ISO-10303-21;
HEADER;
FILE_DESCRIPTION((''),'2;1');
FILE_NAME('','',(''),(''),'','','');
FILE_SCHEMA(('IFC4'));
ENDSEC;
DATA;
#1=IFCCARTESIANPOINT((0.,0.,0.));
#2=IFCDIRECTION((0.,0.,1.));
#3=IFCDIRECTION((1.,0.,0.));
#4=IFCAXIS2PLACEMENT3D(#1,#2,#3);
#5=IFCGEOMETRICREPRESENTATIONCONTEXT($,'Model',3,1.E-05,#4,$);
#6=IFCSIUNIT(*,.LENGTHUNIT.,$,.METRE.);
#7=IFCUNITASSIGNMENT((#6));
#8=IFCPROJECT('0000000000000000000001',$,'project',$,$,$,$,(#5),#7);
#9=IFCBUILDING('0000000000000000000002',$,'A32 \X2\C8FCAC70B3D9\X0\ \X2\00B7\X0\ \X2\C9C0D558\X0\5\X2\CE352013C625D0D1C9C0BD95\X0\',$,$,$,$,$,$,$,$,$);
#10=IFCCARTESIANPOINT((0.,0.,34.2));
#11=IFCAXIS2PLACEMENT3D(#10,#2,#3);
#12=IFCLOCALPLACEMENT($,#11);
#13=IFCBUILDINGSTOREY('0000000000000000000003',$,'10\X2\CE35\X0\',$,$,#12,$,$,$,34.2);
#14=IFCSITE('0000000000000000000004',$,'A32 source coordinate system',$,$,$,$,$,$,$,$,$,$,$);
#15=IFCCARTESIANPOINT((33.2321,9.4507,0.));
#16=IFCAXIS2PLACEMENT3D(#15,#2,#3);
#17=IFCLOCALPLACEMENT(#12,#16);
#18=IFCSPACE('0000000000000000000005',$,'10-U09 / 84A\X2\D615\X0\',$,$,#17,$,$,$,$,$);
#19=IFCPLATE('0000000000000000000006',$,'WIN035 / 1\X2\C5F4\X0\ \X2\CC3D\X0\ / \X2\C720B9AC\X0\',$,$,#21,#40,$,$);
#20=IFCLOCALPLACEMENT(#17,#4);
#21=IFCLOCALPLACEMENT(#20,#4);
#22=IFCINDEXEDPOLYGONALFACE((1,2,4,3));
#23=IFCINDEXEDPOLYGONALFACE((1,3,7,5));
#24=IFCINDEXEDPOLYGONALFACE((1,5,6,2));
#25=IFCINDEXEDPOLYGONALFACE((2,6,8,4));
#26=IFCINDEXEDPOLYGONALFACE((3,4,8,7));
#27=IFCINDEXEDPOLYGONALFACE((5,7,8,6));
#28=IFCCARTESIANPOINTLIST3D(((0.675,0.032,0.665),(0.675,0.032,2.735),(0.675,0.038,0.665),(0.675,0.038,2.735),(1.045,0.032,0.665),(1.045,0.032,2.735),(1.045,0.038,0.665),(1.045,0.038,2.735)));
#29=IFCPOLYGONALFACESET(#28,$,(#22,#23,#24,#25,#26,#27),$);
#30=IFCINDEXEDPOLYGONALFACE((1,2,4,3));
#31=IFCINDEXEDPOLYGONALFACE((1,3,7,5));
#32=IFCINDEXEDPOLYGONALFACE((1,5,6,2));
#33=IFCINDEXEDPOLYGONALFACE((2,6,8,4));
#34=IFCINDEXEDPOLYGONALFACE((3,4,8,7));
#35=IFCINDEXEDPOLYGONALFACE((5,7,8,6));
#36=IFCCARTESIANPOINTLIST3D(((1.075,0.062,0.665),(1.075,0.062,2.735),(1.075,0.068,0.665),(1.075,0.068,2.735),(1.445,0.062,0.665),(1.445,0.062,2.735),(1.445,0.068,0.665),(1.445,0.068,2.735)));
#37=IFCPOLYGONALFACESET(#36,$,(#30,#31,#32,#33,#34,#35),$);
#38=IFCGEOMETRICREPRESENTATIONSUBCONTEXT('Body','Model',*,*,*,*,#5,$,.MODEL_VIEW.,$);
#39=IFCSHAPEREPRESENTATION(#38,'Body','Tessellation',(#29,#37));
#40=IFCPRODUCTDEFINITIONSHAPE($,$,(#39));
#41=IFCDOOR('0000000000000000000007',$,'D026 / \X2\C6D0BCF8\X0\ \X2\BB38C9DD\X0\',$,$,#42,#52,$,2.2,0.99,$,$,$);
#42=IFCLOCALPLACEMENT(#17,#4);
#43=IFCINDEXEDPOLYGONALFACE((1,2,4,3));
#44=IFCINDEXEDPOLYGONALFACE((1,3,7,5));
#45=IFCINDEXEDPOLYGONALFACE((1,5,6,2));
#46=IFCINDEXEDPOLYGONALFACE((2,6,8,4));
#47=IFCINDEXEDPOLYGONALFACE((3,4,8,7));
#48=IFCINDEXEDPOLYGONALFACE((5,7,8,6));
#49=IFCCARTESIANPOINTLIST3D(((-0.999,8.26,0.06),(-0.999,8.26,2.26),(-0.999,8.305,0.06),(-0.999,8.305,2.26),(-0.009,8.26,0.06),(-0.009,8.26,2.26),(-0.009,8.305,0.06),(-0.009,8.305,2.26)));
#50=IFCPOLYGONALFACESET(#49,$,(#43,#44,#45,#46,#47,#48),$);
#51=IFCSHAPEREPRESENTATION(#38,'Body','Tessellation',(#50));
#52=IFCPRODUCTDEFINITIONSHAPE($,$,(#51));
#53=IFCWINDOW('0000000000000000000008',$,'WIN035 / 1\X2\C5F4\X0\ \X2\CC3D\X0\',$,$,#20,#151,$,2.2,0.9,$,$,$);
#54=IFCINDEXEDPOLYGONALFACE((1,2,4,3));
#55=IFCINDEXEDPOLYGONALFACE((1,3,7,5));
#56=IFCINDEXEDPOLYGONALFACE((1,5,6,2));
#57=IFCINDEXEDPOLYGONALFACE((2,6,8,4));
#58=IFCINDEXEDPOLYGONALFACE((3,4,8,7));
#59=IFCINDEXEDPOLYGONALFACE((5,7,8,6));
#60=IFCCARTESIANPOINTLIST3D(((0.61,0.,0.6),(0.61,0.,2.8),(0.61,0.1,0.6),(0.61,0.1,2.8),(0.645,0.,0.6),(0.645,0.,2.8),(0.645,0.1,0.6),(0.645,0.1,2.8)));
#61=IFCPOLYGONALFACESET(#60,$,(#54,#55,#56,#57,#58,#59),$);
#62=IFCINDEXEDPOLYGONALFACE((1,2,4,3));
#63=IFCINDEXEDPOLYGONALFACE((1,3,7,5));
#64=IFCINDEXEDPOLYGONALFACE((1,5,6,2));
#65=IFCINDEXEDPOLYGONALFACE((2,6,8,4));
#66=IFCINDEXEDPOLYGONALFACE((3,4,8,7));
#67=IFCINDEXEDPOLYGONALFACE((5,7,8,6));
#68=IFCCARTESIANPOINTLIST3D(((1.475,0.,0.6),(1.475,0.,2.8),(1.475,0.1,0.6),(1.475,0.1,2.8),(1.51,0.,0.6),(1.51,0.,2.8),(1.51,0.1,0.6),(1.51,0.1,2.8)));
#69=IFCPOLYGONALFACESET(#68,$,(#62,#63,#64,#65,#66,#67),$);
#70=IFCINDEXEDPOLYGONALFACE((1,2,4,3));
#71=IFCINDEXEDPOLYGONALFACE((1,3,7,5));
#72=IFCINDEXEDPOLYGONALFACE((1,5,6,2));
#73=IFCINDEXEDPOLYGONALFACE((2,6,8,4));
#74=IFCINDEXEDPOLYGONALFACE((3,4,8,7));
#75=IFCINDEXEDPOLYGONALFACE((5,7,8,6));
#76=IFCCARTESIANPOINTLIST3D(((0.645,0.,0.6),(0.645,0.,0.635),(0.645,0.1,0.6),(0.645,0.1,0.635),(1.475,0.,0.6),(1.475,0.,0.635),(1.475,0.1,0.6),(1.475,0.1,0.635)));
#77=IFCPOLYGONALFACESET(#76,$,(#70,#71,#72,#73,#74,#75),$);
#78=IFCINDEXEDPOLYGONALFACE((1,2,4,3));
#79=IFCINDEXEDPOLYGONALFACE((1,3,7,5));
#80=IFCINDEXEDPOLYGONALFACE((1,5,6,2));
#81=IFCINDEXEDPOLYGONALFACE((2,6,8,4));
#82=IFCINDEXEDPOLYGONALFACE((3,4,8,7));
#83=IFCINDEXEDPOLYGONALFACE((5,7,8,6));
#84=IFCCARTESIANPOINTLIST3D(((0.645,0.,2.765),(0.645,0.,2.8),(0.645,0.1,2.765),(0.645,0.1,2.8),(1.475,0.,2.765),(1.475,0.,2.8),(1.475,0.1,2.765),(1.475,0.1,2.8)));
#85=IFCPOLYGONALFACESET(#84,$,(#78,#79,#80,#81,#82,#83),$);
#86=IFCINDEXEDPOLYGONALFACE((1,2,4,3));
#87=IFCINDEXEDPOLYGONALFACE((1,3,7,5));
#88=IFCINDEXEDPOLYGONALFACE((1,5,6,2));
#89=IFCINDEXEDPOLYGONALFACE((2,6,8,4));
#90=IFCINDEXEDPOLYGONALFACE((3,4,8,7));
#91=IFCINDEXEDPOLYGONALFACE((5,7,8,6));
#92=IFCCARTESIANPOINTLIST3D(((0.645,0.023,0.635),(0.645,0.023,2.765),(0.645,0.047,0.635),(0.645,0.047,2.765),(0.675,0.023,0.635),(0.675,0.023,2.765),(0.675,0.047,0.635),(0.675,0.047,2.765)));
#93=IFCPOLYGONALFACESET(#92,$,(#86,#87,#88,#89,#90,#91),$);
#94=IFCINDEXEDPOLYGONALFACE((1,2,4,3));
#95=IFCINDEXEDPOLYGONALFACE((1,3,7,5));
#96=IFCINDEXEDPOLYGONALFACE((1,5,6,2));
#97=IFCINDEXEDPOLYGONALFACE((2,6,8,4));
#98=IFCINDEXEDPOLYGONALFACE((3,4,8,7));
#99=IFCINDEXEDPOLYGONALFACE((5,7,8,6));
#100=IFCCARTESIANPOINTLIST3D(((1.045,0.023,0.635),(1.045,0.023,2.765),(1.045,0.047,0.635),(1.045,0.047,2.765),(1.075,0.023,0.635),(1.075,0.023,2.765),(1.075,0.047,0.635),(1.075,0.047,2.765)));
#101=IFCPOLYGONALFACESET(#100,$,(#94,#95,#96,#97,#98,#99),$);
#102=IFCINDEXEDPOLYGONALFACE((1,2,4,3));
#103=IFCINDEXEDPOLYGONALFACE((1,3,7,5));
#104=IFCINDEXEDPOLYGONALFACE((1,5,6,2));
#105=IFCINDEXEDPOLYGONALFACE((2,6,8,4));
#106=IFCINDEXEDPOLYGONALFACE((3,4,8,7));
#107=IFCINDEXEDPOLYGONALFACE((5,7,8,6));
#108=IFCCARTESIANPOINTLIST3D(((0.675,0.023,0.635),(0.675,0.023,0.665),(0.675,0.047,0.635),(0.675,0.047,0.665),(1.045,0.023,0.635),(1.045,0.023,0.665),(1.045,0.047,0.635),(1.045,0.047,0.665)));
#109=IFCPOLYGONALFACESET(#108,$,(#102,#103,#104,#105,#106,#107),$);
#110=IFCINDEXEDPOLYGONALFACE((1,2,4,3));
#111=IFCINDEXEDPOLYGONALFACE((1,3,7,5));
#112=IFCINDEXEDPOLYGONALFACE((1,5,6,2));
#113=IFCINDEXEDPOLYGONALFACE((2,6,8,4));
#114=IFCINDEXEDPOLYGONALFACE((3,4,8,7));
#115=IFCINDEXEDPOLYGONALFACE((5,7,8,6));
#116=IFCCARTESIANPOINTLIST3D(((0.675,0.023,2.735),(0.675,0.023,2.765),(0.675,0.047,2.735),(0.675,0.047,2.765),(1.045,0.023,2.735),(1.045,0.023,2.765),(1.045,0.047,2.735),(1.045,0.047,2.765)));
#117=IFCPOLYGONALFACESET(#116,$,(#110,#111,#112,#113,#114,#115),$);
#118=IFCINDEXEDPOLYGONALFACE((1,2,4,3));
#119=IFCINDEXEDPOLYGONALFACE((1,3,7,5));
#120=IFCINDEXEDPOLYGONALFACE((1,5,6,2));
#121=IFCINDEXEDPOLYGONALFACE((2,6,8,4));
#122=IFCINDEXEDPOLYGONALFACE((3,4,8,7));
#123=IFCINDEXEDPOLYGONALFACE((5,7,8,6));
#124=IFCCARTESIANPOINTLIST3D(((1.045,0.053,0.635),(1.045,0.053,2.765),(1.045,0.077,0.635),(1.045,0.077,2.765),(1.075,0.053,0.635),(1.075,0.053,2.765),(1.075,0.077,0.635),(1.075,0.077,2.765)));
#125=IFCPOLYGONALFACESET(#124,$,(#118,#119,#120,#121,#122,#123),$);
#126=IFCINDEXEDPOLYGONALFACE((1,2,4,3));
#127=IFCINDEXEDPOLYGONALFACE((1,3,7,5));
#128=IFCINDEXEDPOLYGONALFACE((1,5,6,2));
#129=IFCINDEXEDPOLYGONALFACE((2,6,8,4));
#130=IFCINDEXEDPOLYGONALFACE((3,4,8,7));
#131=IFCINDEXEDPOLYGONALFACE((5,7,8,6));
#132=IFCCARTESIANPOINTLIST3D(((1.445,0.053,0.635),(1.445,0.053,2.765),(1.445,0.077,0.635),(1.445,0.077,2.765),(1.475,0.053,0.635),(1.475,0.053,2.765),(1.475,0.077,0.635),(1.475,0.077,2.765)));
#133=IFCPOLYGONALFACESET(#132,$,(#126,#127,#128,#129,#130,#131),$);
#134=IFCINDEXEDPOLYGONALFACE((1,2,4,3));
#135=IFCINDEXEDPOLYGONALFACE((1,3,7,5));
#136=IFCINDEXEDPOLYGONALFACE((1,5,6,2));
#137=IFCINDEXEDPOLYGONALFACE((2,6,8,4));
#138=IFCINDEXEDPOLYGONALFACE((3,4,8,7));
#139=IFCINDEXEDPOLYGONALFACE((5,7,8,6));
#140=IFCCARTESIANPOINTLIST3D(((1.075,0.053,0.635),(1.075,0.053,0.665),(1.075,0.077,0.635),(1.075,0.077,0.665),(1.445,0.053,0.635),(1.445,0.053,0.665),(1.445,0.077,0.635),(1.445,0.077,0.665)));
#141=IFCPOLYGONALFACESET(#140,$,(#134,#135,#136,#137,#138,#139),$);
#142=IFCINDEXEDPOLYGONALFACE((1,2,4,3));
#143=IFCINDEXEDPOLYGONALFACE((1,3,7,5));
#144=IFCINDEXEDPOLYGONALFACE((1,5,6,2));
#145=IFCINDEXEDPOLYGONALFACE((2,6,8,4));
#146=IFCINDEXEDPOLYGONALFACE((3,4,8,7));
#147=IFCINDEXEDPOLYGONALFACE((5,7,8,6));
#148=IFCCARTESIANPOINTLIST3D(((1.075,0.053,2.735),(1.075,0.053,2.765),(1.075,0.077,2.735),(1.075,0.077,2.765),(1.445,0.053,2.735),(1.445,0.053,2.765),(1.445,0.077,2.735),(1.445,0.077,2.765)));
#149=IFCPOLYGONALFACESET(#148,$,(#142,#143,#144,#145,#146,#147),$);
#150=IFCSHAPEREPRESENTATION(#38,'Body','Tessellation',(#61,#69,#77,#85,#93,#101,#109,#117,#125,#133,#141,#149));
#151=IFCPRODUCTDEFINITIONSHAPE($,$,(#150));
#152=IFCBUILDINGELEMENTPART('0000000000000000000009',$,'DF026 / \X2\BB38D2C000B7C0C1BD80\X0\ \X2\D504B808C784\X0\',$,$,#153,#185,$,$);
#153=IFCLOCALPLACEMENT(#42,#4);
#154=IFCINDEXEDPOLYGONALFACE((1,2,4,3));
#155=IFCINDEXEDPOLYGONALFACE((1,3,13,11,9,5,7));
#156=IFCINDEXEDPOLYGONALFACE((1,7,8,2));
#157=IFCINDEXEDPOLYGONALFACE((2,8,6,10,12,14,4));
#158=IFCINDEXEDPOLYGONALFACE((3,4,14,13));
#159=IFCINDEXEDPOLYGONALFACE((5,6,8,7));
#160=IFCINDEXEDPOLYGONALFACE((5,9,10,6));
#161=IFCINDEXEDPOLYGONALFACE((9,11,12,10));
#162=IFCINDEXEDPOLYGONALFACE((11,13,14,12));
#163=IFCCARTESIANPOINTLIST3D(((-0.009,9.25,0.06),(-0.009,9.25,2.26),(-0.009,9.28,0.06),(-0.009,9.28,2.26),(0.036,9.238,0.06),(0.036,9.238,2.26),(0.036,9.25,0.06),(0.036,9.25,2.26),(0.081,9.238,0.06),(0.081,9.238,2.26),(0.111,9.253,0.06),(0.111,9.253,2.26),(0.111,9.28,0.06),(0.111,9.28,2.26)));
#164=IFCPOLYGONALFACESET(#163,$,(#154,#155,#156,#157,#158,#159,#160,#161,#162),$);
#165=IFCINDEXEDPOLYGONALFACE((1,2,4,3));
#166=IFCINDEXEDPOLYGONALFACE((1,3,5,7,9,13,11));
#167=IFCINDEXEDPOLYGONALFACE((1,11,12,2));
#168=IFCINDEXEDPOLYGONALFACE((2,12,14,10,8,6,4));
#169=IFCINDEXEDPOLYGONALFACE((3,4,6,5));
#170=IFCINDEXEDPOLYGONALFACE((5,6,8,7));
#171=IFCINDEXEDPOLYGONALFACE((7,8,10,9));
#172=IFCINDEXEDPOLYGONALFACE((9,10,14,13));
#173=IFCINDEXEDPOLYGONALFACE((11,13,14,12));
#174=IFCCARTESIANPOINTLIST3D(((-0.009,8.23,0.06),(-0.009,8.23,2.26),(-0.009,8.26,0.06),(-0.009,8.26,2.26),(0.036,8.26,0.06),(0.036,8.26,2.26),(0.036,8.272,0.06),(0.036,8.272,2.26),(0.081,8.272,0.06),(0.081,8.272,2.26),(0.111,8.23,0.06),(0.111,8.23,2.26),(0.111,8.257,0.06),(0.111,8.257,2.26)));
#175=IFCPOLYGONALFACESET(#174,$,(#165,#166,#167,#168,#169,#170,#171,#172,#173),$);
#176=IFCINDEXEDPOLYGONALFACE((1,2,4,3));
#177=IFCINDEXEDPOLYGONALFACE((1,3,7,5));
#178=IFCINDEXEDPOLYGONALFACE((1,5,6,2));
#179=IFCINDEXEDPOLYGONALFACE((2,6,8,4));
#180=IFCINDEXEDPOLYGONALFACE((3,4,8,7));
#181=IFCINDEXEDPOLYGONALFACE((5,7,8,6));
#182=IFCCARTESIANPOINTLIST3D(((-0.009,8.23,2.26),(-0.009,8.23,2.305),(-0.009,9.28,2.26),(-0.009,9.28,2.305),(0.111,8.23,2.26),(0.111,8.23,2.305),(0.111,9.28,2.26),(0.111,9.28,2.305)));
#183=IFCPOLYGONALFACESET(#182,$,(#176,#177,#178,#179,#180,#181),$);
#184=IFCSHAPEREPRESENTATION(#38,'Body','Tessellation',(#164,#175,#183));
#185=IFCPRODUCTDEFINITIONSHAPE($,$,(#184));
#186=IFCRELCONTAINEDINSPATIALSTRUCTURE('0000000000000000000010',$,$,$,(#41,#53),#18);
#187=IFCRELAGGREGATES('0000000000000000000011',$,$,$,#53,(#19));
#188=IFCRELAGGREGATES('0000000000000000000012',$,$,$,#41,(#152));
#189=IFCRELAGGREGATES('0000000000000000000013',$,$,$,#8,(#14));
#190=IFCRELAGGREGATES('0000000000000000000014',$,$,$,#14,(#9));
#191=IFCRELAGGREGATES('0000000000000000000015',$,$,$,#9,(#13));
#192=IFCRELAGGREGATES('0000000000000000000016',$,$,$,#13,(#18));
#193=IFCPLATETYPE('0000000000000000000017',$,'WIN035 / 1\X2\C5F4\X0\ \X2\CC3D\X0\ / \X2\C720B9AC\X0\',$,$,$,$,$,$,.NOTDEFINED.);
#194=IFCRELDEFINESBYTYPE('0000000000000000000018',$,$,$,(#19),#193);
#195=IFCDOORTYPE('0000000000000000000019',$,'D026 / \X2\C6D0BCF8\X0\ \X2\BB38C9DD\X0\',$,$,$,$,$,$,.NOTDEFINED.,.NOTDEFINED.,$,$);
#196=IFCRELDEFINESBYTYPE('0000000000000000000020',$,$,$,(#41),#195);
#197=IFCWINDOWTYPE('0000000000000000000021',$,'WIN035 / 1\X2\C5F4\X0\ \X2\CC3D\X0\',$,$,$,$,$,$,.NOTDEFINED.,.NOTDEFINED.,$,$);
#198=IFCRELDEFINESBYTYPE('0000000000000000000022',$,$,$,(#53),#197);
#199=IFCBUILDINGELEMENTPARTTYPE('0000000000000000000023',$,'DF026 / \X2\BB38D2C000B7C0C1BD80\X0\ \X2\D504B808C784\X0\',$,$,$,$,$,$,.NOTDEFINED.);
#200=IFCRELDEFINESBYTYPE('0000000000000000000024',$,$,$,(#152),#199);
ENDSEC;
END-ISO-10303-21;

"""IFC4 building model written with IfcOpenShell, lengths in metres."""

from ifc_helpers import new_model, si_unit, frame, origin, origin_with_axes, place, context, subcontext, project, spatial, polyline, outline, extrude, source, transform, mapped, type_object, type_shapes, element, aggregate, save


model = new_model("IFC4")

# Units and contexts
model_context = context("Model", 3, precision=1e-05, world=origin_with_axes())
body_context = subcontext(model_context, "Body", "Model", "MODEL_VIEW")
ifc_project = project(units=[si_unit("LENGTHUNIT", "METRE")], contexts=[model_context])

# Plate
plate_type_1 = type_object("IfcPlateType", Name="WIN035 / 1열 창 / 유리", PredefinedType="NOTDEFINED")
shared_shape_1 = source(origin(), body_context, "Body", "SweptSolid", [
    extrude(outline(polyline([(0.675, 0.032), (0.675, 0.038), (1.045, 0.038), (1.045, 0.032), (0.675, 0.032)])), frame((0.0, 0.0, 0.665)), (0.0, 0.0, 1.0), 2.07),
    extrude(outline(polyline([(1.075, 0.062), (1.075, 0.068), (1.445, 0.068), (1.445, 0.062), (1.075, 0.062)])), frame((0.0, 0.0, 0.665)), (0.0, 0.0, 1.0), 2.07),
])
type_shapes(plate_type_1, [shared_shape_1])
storey_placement = place(None, frame((0.0, 0.0, 34.2), z_axis=(0.0, 0.0, 1.0), x_axis=(1.0, 0.0, 0.0)))
space_placement = place(storey_placement, frame((33.2321, 9.4507, 0.0), z_axis=(0.0, 0.0, 1.0), x_axis=(1.0, 0.0, 0.0)))
window_1_placement = place(space_placement, origin_with_axes())
plate_1_placement = place(window_1_placement, origin_with_axes())
plate_1 = element("IfcPlate", 1, at=plate_1_placement, type_object=plate_type_1, Name="WIN035 / 1열 창 / 유리", context=body_context, shape_type="MappedRepresentation", body=[
    mapped(shared_shape_1, transform((0.0, 0.0, 0.0), scale=1.0)),
])

# Site, building, storey, space
site = spatial("IfcSite", under=ifc_project, Name="A32 source coordinate system")
building = spatial("IfcBuilding", under=site, Name="A32 주거동 · 지하5층–옥탑지붕")
storey = spatial("IfcBuildingStorey", under=building, at=storey_placement, Name="10층", Elevation=34.2)
space = spatial("IfcSpace", under=storey, at=space_placement, Name="10-U09 / 84A형")

# Door
door_type_1 = type_object("IfcDoorType", Name="D026 / 원본 문짝", OperationType="NOTDEFINED", PredefinedType="NOTDEFINED")
shared_shape_2 = source(origin(), body_context, "Body", "SweptSolid", [
    extrude(outline(polyline([(-0.009, 8.26), (-0.999, 8.26), (-0.999, 8.305), (-0.009, 8.305), (-0.009, 8.26)])), frame((0.0, 0.0, 0.06)), (0.0, 0.0, 1.0), 2.2),
])
type_shapes(door_type_1, [shared_shape_2])
door_1_placement = place(space_placement, origin_with_axes())
door_1 = element("IfcDoor", 2, at=door_1_placement, inside=space, type_object=door_type_1, Name="D026 / 원본 문짝", OverallHeight=2.2, OverallWidth=0.99, context=body_context, shape_type="MappedRepresentation", body=[
    mapped(shared_shape_2, transform((0.0, 0.0, 0.0), scale=1.0)),
])

# Window
window_type_1 = type_object("IfcWindowType", Name="WIN035 / 1열 창", PartitioningType="NOTDEFINED", PredefinedType="NOTDEFINED")
shared_shape_3 = source(origin(), body_context, "Body", "SweptSolid", [
    extrude(outline(polyline([(0.61, 0.0), (0.61, 0.1), (0.645, 0.1), (0.645, 0.0), (0.61, 0.0)])), frame((0.0, 0.0, 0.6)), (0.0, 0.0, 1.0), 2.2),
    extrude(outline(polyline([(1.475, 0.0), (1.475, 0.1), (1.51, 0.1), (1.51, 0.0), (1.475, 0.0)])), frame((0.0, 0.0, 0.6)), (0.0, 0.0, 1.0), 2.2),
    extrude(outline(polyline([(0.645, 0.0), (0.645, 0.1), (1.475, 0.1), (1.475, 0.0), (0.645, 0.0)])), frame((0.0, 0.0, 0.6)), (0.0, 0.0, 1.0), 0.035),
    extrude(outline(polyline([(0.645, 0.0), (0.645, 0.1), (1.475, 0.1), (1.475, 0.0), (0.645, 0.0)])), frame((0.0, 0.0, 2.765)), (0.0, 0.0, 1.0), 0.035),
    extrude(outline(polyline([(0.645, 0.023), (0.645, 0.047), (0.675, 0.047), (0.675, 0.023), (0.645, 0.023)])), frame((0.0, 0.0, 0.635)), (0.0, 0.0, 1.0), 2.13),
    extrude(outline(polyline([(1.045, 0.023), (1.045, 0.047), (1.075, 0.047), (1.075, 0.023), (1.045, 0.023)])), frame((0.0, 0.0, 0.635)), (0.0, 0.0, 1.0), 2.13),
    extrude(outline(polyline([(0.675, 0.023), (0.675, 0.047), (1.045, 0.047), (1.045, 0.023), (0.675, 0.023)])), frame((0.0, 0.0, 0.635)), (0.0, 0.0, 1.0), 0.03),
    extrude(outline(polyline([(0.675, 0.023), (0.675, 0.047), (1.045, 0.047), (1.045, 0.023), (0.675, 0.023)])), frame((0.0, 0.0, 2.735)), (0.0, 0.0, 1.0), 0.03),
    extrude(outline(polyline([(1.045, 0.053), (1.045, 0.077), (1.075, 0.077), (1.075, 0.053), (1.045, 0.053)])), frame((0.0, 0.0, 0.635)), (0.0, 0.0, 1.0), 2.13),
    extrude(outline(polyline([(1.445, 0.053), (1.445, 0.077), (1.475, 0.077), (1.475, 0.053), (1.445, 0.053)])), frame((0.0, 0.0, 0.635)), (0.0, 0.0, 1.0), 2.13),
    extrude(outline(polyline([(1.075, 0.053), (1.075, 0.077), (1.445, 0.077), (1.445, 0.053), (1.075, 0.053)])), frame((0.0, 0.0, 0.635)), (0.0, 0.0, 1.0), 0.03),
    extrude(outline(polyline([(1.075, 0.053), (1.075, 0.077), (1.445, 0.077), (1.445, 0.053), (1.075, 0.053)])), frame((0.0, 0.0, 2.735)), (0.0, 0.0, 1.0), 0.03),
])
type_shapes(window_type_1, [shared_shape_3])
window_1 = element("IfcWindow", 3, at=window_1_placement, inside=space, type_object=window_type_1, Name="WIN035 / 1열 창", OverallHeight=2.2, OverallWidth=0.9, context=body_context, shape_type="MappedRepresentation", body=[
    mapped(shared_shape_3, transform((0.0, 0.0, 0.0), scale=1.0)),
])
aggregate(window_1, [plate_1])

# Building element part
building_element_part_type_1 = type_object("IfcBuildingElementPartType", Name="DF026 / 문틀·상부 프레임", PredefinedType="NOTDEFINED")
shared_shape_4 = source(origin(), body_context, "Body", "SweptSolid", [
    extrude(outline(polyline([(0.111, 9.28), (0.111, 9.253), (0.081, 9.238), (0.036, 9.238), (0.036, 9.25), (-0.009, 9.25), (-0.009, 9.28), (0.111, 9.28)])), frame((0.0, 0.0, 0.06)), (0.0, 0.0, 1.0), 2.2),
    extrude(outline(polyline([(-0.009, 8.26), (0.036, 8.26), (0.036, 8.272), (0.081, 8.272), (0.111, 8.257), (0.111, 8.23), (-0.009, 8.23), (-0.009, 8.26)])), frame((0.0, 0.0, 0.06)), (0.0, 0.0, 1.0), 2.2),
    extrude(outline(polyline([(-0.009, 8.23), (-0.009, 9.28), (0.111, 9.28), (0.111, 8.23), (-0.009, 8.23)])), frame((0.0, 0.0, 2.26)), (0.0, 0.0, 1.0), 0.045),
])
type_shapes(building_element_part_type_1, [shared_shape_4])
building_element_part_1_placement = place(door_1_placement, origin_with_axes())
building_element_part_1 = element("IfcBuildingElementPart", 4, at=building_element_part_1_placement, type_object=building_element_part_type_1, Name="DF026 / 문틀·상부 프레임", context=body_context, shape_type="MappedRepresentation", body=[
    mapped(shared_shape_4, transform((0.0, 0.0, 0.0), scale=1.0)),
])
aggregate(door_1, [building_element_part_1])

save(model, "model.ifc")
